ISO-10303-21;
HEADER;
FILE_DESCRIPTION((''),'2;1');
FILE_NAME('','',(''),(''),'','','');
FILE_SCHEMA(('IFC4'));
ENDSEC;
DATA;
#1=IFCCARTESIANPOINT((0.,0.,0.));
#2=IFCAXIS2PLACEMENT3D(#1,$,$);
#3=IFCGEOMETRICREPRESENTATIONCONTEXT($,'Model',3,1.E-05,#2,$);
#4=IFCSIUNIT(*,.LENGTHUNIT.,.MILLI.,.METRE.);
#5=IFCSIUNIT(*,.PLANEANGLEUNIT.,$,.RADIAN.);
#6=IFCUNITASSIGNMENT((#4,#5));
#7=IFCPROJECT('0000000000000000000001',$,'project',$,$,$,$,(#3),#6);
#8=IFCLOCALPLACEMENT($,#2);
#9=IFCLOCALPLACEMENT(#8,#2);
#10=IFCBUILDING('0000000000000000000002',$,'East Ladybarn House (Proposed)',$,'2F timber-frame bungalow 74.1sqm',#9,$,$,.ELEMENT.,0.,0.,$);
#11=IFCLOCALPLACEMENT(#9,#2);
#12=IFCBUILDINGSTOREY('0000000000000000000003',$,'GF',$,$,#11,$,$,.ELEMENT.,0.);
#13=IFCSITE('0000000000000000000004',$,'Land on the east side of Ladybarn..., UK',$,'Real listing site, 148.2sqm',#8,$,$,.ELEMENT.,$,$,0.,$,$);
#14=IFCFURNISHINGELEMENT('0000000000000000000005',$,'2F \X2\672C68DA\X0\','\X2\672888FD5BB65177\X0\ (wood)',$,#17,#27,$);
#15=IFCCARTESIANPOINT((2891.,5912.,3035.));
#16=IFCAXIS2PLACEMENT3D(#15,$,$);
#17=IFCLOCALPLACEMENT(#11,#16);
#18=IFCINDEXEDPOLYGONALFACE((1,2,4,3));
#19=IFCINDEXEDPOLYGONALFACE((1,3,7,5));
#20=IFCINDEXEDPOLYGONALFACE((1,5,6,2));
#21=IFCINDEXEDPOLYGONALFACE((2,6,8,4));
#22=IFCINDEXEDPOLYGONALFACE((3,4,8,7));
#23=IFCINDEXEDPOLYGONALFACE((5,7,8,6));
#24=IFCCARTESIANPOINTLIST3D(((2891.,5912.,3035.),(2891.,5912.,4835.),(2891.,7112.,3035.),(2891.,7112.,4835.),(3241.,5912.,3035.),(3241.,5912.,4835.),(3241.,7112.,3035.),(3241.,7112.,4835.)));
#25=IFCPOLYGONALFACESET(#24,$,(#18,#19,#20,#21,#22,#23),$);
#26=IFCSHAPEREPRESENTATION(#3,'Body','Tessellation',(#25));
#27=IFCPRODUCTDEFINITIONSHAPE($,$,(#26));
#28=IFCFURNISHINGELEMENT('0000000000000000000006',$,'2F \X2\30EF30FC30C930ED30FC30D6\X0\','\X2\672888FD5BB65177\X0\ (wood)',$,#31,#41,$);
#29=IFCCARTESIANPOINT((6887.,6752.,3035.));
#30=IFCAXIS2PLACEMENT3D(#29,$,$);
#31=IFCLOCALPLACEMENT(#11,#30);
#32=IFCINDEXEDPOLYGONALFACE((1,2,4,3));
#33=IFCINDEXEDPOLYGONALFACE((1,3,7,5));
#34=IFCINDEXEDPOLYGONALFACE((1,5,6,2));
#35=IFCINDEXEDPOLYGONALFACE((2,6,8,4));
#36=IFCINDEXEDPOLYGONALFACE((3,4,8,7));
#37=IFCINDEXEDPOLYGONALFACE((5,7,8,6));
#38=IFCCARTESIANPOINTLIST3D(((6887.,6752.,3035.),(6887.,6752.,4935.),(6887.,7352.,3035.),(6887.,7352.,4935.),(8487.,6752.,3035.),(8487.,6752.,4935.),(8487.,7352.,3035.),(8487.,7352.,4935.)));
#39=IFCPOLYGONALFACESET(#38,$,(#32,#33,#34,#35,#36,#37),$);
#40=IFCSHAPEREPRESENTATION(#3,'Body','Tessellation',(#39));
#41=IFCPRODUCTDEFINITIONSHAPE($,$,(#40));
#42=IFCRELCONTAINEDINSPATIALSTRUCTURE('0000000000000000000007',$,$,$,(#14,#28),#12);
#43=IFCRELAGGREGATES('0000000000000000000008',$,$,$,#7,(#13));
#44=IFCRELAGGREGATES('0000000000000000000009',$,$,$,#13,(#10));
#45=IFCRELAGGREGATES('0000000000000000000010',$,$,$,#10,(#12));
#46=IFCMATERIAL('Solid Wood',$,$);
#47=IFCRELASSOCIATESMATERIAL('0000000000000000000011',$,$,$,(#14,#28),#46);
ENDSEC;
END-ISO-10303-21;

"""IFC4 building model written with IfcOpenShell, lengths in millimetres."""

from ifc_helpers import new_model, si_unit, frame, frame_2d, origin, place, context, project, spatial, rectangle, extrude, material, element, save


model = new_model("IFC4")

# Units and contexts
model_context = context("Model", 3, precision=1e-05, world=origin())
ifc_project = project(units=[si_unit("LENGTHUNIT", "METRE", prefix="MILLI"), si_unit("PLANEANGLEUNIT", "RADIAN")], contexts=[model_context])

# Site, building, storey
site_placement = place(None, origin())
site = spatial("IfcSite", under=ifc_project, at=site_placement, Name="Land on the east side of Ladybarn..., UK", ObjectType="Real listing site, 148.2sqm", CompositionType="ELEMENT", RefElevation=0.0)
building_placement = place(site_placement, origin())
building = spatial("IfcBuilding", under=site, at=building_placement, Name="East Ladybarn House (Proposed)", ObjectType="2F timber-frame bungalow 74.1sqm", CompositionType="ELEMENT", ElevationOfRefHeight=0.0, ElevationOfTerrain=0.0)
storey_placement = place(building_placement, origin())
storey = spatial("IfcBuildingStorey", under=building, at=storey_placement, Name="GF", CompositionType="ELEMENT", Elevation=0.0)

# Shared definitions
ifc_material_1 = material(Name="Solid Wood")

# Furnishing elements
furnishing_1_placement = place(storey_placement, frame((2891.0, 5912.0, 3035.0)))
element("IfcFurnishingElement", 1, at=furnishing_1_placement, inside=storey, material=ifc_material_1, Name="2F 本棚", Description="木製家具 (wood)", context=model_context, shape_type="SweptSolid", body=[
    extrude(rectangle(XDim=350.0, YDim=1200.0, at=frame_2d((175.0, 600.0))), frame((2891.0, 5912.0, 3035.0)), (0.0, 0.0, 1.0), 1800.0),
])
furnishing_2_placement = place(storey_placement, frame((6887.0, 6752.0, 3035.0)))
element("IfcFurnishingElement", 2, at=furnishing_2_placement, inside=storey, material=ifc_material_1, Name="2F ワードローブ", Description="木製家具 (wood)", context=model_context, shape_type="SweptSolid", body=[
    extrude(rectangle(XDim=1600.0, YDim=600.0, at=frame_2d((800.0, 300.0))), frame((6887.0, 6752.0, 3035.0)), (0.0, 0.0, 1.0), 1900.0),
])

save(model, "model.ifc")
